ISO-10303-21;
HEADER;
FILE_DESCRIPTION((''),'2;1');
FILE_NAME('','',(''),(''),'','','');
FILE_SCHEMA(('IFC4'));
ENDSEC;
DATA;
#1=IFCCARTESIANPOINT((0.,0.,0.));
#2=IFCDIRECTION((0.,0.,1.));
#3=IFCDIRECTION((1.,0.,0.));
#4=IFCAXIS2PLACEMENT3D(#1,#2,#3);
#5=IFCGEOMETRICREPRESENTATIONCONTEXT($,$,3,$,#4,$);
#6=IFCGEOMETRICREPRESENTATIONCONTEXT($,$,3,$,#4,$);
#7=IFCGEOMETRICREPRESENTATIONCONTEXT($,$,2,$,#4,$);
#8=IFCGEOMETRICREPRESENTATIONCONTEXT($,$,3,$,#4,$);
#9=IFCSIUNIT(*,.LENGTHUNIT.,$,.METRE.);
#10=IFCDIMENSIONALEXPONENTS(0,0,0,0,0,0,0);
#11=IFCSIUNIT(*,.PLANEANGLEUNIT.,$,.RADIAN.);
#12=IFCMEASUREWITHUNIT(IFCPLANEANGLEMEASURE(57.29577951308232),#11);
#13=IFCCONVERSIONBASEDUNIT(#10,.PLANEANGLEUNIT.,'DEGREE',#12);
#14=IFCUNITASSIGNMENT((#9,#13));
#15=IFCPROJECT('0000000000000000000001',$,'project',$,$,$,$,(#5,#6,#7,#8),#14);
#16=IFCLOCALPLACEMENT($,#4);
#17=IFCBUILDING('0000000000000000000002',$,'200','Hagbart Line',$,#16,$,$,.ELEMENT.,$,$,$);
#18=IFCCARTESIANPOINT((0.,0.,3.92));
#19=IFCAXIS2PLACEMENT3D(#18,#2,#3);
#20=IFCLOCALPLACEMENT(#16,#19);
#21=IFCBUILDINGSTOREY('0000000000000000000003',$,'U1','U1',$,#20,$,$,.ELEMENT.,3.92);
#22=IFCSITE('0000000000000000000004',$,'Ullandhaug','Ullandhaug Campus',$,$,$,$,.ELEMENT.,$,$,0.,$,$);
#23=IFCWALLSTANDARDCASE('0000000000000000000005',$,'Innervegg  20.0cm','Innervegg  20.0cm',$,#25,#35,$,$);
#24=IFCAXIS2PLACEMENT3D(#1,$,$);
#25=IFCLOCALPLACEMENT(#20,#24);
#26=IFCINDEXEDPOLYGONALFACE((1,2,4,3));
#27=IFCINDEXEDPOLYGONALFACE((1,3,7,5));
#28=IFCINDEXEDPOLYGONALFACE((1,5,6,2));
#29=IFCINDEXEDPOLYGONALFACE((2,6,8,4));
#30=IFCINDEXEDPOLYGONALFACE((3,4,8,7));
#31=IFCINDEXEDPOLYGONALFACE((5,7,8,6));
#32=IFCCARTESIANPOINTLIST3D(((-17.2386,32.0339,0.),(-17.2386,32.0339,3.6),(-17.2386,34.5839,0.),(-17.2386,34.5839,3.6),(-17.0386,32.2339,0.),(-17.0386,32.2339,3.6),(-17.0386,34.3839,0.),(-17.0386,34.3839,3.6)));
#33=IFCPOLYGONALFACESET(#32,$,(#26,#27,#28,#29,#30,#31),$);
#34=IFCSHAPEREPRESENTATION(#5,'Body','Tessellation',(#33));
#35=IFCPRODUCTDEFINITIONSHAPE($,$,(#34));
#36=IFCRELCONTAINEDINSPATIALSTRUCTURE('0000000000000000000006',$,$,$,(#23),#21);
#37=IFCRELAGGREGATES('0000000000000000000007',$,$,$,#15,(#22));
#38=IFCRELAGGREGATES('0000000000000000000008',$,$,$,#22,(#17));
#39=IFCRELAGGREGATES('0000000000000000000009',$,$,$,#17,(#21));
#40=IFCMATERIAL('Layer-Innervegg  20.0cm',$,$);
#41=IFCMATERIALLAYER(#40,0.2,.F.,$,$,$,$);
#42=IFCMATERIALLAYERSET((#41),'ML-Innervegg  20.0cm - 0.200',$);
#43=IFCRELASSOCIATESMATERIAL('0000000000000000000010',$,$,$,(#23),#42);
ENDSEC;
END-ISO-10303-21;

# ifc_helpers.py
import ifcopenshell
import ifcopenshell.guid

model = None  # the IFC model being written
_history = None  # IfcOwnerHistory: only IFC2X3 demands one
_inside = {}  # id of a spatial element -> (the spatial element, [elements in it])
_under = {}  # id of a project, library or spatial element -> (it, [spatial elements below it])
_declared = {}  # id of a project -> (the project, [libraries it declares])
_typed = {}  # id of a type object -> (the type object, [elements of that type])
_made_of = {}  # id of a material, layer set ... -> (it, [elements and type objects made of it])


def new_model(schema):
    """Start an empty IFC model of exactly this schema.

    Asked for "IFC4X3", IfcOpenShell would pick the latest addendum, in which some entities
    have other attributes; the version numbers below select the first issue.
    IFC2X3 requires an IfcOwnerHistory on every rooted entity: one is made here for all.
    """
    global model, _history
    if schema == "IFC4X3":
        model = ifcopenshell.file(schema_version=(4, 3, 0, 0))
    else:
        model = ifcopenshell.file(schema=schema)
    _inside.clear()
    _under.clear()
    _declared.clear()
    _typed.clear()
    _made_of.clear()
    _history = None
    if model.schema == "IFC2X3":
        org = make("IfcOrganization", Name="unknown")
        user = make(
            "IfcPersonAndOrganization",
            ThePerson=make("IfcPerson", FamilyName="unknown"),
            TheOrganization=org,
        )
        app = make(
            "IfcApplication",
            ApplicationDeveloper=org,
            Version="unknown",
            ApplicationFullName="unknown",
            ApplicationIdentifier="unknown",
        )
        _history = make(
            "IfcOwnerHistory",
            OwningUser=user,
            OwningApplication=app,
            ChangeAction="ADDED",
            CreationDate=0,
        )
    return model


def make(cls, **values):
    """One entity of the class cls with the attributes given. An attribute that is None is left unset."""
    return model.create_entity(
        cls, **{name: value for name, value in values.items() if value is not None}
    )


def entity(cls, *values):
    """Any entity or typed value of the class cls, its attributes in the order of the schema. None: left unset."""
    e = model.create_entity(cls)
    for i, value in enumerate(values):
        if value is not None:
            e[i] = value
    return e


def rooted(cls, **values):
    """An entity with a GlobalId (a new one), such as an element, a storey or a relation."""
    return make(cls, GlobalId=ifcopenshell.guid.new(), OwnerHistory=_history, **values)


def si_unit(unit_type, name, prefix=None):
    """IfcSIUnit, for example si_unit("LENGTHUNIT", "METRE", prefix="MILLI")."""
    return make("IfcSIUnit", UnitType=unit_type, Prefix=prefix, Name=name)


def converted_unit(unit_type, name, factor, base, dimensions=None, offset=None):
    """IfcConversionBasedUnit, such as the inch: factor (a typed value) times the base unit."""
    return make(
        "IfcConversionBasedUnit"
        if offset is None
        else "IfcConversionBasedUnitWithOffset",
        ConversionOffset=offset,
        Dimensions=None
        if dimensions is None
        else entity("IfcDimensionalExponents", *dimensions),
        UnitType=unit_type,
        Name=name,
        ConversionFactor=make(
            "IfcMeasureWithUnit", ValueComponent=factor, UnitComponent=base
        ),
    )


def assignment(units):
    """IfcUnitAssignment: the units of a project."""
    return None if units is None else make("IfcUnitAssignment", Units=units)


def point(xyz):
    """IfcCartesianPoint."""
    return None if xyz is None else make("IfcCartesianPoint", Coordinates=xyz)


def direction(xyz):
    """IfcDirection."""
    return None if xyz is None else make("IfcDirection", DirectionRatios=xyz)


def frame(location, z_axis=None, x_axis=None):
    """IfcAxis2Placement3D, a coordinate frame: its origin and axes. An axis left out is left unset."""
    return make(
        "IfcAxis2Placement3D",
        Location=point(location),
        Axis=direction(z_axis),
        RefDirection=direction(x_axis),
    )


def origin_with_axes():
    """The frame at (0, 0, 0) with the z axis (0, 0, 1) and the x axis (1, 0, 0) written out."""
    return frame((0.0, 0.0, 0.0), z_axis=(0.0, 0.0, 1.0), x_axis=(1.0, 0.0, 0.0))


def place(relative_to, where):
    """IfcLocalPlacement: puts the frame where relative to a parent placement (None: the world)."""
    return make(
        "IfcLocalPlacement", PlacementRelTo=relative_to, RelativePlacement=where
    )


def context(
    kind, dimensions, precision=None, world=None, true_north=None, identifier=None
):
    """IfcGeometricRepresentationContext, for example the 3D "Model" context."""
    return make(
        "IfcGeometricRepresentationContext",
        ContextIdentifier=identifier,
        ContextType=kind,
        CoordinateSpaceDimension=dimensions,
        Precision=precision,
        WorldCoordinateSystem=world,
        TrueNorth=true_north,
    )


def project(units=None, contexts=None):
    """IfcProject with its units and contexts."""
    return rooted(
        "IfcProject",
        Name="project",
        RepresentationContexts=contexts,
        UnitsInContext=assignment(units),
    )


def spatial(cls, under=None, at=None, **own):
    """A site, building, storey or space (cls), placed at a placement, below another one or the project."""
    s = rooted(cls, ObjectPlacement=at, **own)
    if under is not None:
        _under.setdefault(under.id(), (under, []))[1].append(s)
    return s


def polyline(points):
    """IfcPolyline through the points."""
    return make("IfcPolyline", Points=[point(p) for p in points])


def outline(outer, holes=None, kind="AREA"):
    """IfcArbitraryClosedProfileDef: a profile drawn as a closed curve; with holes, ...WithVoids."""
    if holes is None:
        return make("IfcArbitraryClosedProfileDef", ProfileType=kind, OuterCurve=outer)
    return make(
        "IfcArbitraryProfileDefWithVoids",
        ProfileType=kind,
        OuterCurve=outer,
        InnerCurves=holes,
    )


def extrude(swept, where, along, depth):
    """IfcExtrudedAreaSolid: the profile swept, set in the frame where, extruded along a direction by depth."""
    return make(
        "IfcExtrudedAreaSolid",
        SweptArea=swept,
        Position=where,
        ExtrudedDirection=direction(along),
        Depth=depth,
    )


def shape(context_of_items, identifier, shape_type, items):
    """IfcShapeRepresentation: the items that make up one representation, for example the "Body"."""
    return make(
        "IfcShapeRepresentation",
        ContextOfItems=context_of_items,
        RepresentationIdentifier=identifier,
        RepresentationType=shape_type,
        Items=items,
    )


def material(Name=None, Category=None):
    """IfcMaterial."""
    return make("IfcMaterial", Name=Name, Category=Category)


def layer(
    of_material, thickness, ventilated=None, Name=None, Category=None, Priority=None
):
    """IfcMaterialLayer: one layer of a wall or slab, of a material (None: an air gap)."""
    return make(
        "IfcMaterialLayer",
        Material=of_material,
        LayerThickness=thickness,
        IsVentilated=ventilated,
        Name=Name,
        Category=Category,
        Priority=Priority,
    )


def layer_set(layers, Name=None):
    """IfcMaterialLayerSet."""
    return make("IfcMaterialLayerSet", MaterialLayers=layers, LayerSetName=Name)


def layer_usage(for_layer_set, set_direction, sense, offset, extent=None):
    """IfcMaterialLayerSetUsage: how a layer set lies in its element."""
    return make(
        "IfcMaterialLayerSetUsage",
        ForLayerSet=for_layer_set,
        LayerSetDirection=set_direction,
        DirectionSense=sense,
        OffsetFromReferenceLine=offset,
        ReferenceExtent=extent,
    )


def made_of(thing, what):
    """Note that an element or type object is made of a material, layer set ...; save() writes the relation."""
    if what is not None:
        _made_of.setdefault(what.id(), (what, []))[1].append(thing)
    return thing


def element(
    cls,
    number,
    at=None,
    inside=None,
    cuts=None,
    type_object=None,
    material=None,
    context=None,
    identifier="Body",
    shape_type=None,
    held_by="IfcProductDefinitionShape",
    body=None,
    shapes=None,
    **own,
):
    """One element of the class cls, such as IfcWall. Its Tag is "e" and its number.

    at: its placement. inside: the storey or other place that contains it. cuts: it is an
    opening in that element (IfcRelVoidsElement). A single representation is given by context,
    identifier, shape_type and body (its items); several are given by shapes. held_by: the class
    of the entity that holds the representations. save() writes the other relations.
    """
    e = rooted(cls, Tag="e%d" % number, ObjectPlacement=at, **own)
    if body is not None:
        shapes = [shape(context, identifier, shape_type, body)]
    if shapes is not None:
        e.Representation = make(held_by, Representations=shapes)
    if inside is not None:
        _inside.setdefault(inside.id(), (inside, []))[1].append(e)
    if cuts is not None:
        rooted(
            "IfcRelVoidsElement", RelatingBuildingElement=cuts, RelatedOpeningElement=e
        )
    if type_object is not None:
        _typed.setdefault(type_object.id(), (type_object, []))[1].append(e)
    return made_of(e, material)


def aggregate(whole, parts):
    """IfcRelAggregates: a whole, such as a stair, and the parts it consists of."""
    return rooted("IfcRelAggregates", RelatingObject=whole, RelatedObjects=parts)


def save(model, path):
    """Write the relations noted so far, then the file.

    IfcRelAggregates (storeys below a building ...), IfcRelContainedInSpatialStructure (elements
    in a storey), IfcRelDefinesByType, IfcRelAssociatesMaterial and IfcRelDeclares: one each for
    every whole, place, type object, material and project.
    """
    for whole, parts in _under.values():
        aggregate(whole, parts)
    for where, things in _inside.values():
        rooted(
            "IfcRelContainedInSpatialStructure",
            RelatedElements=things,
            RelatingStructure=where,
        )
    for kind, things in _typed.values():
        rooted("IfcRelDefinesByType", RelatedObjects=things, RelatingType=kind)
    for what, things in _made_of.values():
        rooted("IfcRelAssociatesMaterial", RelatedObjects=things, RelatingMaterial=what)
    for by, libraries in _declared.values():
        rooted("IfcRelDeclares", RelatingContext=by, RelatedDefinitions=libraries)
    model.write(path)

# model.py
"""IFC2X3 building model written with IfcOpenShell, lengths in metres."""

from ifc_helpers import new_model, entity, si_unit, converted_unit, frame, origin_with_axes, place, context, project, spatial, polyline, outline, extrude, material, layer, layer_set, layer_usage, element, save


model = new_model("IFC2X3")

# Units and contexts
context_of_model_1 = context(None, 3, world=origin_with_axes())
context_of_model_2 = context(None, 3, world=origin_with_axes())
context_of_model_3 = context(None, 2, world=origin_with_axes())
context_of_model_4 = context(None, 3, world=origin_with_axes())
ifc_project = project(units=[si_unit("LENGTHUNIT", "METRE"), converted_unit("PLANEANGLEUNIT", "DEGREE", entity("IfcPlaneAngleMeasure", 57.29577951308232), si_unit("PLANEANGLEUNIT", "RADIAN"), dimensions=[0, 0, 0, 0, 0, 0, 0])], contexts=[context_of_model_1, context_of_model_2, context_of_model_3, context_of_model_4])

# Site, building, storey
site = spatial("IfcSite", under=ifc_project, Name="Ullandhaug", Description="Ullandhaug Campus", CompositionType="ELEMENT", RefElevation=0.0)
building_placement = place(None, origin_with_axes())
building = spatial("IfcBuilding", under=site, at=building_placement, Name="200", Description="Hagbart Line", CompositionType="ELEMENT")
storey_placement = place(building_placement, frame((0.0, 0.0, 3.92), z_axis=(0.0, 0.0, 1.0), x_axis=(1.0, 0.0, 0.0)))
storey = spatial("IfcBuildingStorey", under=building, at=storey_placement, Name="U1", Description="U1", CompositionType="ELEMENT", Elevation=3.92)

# Shared definitions
ifc_material_1 = material(Name="Layer-Innervegg  20.0cm")
ifc_layer_1 = layer(ifc_material_1, 0.2, ventilated=False)
ifc_layer_set_1 = layer_set([ifc_layer_1], Name="ML-Innervegg  20.0cm - 0.200")
ifc_layer_usage_1 = layer_usage(ifc_layer_set_1, "AXIS2", "POSITIVE", 0.0)

# Wall
wall_1_placement = place(storey_placement, frame((-17.2386, 34.5839, 0.0), z_axis=(0.0, 0.0, 1.0), x_axis=(0.0, -1.0, 0.0)))
element("IfcWallStandardCase", 1, at=wall_1_placement, inside=storey, material=ifc_layer_usage_1, Name="Innervegg  20.0cm", Description="Innervegg  20.0cm", context=context_of_model_1, shape_type="SweptSolid", body=[
    extrude(outline(polyline([(0.0, 0.0), (2.55, 0.0), (2.35, 0.2), (0.2, 0.2), (0.0, 0.0)])), frame((0.0, 0.0, 0.0), z_axis=(0.0, 0.0, 1.0), x_axis=(1.0, 0.0, 0.0)), (0.0, 0.0, 1.0), 3.6),
])

save(model, "model.ifc")
